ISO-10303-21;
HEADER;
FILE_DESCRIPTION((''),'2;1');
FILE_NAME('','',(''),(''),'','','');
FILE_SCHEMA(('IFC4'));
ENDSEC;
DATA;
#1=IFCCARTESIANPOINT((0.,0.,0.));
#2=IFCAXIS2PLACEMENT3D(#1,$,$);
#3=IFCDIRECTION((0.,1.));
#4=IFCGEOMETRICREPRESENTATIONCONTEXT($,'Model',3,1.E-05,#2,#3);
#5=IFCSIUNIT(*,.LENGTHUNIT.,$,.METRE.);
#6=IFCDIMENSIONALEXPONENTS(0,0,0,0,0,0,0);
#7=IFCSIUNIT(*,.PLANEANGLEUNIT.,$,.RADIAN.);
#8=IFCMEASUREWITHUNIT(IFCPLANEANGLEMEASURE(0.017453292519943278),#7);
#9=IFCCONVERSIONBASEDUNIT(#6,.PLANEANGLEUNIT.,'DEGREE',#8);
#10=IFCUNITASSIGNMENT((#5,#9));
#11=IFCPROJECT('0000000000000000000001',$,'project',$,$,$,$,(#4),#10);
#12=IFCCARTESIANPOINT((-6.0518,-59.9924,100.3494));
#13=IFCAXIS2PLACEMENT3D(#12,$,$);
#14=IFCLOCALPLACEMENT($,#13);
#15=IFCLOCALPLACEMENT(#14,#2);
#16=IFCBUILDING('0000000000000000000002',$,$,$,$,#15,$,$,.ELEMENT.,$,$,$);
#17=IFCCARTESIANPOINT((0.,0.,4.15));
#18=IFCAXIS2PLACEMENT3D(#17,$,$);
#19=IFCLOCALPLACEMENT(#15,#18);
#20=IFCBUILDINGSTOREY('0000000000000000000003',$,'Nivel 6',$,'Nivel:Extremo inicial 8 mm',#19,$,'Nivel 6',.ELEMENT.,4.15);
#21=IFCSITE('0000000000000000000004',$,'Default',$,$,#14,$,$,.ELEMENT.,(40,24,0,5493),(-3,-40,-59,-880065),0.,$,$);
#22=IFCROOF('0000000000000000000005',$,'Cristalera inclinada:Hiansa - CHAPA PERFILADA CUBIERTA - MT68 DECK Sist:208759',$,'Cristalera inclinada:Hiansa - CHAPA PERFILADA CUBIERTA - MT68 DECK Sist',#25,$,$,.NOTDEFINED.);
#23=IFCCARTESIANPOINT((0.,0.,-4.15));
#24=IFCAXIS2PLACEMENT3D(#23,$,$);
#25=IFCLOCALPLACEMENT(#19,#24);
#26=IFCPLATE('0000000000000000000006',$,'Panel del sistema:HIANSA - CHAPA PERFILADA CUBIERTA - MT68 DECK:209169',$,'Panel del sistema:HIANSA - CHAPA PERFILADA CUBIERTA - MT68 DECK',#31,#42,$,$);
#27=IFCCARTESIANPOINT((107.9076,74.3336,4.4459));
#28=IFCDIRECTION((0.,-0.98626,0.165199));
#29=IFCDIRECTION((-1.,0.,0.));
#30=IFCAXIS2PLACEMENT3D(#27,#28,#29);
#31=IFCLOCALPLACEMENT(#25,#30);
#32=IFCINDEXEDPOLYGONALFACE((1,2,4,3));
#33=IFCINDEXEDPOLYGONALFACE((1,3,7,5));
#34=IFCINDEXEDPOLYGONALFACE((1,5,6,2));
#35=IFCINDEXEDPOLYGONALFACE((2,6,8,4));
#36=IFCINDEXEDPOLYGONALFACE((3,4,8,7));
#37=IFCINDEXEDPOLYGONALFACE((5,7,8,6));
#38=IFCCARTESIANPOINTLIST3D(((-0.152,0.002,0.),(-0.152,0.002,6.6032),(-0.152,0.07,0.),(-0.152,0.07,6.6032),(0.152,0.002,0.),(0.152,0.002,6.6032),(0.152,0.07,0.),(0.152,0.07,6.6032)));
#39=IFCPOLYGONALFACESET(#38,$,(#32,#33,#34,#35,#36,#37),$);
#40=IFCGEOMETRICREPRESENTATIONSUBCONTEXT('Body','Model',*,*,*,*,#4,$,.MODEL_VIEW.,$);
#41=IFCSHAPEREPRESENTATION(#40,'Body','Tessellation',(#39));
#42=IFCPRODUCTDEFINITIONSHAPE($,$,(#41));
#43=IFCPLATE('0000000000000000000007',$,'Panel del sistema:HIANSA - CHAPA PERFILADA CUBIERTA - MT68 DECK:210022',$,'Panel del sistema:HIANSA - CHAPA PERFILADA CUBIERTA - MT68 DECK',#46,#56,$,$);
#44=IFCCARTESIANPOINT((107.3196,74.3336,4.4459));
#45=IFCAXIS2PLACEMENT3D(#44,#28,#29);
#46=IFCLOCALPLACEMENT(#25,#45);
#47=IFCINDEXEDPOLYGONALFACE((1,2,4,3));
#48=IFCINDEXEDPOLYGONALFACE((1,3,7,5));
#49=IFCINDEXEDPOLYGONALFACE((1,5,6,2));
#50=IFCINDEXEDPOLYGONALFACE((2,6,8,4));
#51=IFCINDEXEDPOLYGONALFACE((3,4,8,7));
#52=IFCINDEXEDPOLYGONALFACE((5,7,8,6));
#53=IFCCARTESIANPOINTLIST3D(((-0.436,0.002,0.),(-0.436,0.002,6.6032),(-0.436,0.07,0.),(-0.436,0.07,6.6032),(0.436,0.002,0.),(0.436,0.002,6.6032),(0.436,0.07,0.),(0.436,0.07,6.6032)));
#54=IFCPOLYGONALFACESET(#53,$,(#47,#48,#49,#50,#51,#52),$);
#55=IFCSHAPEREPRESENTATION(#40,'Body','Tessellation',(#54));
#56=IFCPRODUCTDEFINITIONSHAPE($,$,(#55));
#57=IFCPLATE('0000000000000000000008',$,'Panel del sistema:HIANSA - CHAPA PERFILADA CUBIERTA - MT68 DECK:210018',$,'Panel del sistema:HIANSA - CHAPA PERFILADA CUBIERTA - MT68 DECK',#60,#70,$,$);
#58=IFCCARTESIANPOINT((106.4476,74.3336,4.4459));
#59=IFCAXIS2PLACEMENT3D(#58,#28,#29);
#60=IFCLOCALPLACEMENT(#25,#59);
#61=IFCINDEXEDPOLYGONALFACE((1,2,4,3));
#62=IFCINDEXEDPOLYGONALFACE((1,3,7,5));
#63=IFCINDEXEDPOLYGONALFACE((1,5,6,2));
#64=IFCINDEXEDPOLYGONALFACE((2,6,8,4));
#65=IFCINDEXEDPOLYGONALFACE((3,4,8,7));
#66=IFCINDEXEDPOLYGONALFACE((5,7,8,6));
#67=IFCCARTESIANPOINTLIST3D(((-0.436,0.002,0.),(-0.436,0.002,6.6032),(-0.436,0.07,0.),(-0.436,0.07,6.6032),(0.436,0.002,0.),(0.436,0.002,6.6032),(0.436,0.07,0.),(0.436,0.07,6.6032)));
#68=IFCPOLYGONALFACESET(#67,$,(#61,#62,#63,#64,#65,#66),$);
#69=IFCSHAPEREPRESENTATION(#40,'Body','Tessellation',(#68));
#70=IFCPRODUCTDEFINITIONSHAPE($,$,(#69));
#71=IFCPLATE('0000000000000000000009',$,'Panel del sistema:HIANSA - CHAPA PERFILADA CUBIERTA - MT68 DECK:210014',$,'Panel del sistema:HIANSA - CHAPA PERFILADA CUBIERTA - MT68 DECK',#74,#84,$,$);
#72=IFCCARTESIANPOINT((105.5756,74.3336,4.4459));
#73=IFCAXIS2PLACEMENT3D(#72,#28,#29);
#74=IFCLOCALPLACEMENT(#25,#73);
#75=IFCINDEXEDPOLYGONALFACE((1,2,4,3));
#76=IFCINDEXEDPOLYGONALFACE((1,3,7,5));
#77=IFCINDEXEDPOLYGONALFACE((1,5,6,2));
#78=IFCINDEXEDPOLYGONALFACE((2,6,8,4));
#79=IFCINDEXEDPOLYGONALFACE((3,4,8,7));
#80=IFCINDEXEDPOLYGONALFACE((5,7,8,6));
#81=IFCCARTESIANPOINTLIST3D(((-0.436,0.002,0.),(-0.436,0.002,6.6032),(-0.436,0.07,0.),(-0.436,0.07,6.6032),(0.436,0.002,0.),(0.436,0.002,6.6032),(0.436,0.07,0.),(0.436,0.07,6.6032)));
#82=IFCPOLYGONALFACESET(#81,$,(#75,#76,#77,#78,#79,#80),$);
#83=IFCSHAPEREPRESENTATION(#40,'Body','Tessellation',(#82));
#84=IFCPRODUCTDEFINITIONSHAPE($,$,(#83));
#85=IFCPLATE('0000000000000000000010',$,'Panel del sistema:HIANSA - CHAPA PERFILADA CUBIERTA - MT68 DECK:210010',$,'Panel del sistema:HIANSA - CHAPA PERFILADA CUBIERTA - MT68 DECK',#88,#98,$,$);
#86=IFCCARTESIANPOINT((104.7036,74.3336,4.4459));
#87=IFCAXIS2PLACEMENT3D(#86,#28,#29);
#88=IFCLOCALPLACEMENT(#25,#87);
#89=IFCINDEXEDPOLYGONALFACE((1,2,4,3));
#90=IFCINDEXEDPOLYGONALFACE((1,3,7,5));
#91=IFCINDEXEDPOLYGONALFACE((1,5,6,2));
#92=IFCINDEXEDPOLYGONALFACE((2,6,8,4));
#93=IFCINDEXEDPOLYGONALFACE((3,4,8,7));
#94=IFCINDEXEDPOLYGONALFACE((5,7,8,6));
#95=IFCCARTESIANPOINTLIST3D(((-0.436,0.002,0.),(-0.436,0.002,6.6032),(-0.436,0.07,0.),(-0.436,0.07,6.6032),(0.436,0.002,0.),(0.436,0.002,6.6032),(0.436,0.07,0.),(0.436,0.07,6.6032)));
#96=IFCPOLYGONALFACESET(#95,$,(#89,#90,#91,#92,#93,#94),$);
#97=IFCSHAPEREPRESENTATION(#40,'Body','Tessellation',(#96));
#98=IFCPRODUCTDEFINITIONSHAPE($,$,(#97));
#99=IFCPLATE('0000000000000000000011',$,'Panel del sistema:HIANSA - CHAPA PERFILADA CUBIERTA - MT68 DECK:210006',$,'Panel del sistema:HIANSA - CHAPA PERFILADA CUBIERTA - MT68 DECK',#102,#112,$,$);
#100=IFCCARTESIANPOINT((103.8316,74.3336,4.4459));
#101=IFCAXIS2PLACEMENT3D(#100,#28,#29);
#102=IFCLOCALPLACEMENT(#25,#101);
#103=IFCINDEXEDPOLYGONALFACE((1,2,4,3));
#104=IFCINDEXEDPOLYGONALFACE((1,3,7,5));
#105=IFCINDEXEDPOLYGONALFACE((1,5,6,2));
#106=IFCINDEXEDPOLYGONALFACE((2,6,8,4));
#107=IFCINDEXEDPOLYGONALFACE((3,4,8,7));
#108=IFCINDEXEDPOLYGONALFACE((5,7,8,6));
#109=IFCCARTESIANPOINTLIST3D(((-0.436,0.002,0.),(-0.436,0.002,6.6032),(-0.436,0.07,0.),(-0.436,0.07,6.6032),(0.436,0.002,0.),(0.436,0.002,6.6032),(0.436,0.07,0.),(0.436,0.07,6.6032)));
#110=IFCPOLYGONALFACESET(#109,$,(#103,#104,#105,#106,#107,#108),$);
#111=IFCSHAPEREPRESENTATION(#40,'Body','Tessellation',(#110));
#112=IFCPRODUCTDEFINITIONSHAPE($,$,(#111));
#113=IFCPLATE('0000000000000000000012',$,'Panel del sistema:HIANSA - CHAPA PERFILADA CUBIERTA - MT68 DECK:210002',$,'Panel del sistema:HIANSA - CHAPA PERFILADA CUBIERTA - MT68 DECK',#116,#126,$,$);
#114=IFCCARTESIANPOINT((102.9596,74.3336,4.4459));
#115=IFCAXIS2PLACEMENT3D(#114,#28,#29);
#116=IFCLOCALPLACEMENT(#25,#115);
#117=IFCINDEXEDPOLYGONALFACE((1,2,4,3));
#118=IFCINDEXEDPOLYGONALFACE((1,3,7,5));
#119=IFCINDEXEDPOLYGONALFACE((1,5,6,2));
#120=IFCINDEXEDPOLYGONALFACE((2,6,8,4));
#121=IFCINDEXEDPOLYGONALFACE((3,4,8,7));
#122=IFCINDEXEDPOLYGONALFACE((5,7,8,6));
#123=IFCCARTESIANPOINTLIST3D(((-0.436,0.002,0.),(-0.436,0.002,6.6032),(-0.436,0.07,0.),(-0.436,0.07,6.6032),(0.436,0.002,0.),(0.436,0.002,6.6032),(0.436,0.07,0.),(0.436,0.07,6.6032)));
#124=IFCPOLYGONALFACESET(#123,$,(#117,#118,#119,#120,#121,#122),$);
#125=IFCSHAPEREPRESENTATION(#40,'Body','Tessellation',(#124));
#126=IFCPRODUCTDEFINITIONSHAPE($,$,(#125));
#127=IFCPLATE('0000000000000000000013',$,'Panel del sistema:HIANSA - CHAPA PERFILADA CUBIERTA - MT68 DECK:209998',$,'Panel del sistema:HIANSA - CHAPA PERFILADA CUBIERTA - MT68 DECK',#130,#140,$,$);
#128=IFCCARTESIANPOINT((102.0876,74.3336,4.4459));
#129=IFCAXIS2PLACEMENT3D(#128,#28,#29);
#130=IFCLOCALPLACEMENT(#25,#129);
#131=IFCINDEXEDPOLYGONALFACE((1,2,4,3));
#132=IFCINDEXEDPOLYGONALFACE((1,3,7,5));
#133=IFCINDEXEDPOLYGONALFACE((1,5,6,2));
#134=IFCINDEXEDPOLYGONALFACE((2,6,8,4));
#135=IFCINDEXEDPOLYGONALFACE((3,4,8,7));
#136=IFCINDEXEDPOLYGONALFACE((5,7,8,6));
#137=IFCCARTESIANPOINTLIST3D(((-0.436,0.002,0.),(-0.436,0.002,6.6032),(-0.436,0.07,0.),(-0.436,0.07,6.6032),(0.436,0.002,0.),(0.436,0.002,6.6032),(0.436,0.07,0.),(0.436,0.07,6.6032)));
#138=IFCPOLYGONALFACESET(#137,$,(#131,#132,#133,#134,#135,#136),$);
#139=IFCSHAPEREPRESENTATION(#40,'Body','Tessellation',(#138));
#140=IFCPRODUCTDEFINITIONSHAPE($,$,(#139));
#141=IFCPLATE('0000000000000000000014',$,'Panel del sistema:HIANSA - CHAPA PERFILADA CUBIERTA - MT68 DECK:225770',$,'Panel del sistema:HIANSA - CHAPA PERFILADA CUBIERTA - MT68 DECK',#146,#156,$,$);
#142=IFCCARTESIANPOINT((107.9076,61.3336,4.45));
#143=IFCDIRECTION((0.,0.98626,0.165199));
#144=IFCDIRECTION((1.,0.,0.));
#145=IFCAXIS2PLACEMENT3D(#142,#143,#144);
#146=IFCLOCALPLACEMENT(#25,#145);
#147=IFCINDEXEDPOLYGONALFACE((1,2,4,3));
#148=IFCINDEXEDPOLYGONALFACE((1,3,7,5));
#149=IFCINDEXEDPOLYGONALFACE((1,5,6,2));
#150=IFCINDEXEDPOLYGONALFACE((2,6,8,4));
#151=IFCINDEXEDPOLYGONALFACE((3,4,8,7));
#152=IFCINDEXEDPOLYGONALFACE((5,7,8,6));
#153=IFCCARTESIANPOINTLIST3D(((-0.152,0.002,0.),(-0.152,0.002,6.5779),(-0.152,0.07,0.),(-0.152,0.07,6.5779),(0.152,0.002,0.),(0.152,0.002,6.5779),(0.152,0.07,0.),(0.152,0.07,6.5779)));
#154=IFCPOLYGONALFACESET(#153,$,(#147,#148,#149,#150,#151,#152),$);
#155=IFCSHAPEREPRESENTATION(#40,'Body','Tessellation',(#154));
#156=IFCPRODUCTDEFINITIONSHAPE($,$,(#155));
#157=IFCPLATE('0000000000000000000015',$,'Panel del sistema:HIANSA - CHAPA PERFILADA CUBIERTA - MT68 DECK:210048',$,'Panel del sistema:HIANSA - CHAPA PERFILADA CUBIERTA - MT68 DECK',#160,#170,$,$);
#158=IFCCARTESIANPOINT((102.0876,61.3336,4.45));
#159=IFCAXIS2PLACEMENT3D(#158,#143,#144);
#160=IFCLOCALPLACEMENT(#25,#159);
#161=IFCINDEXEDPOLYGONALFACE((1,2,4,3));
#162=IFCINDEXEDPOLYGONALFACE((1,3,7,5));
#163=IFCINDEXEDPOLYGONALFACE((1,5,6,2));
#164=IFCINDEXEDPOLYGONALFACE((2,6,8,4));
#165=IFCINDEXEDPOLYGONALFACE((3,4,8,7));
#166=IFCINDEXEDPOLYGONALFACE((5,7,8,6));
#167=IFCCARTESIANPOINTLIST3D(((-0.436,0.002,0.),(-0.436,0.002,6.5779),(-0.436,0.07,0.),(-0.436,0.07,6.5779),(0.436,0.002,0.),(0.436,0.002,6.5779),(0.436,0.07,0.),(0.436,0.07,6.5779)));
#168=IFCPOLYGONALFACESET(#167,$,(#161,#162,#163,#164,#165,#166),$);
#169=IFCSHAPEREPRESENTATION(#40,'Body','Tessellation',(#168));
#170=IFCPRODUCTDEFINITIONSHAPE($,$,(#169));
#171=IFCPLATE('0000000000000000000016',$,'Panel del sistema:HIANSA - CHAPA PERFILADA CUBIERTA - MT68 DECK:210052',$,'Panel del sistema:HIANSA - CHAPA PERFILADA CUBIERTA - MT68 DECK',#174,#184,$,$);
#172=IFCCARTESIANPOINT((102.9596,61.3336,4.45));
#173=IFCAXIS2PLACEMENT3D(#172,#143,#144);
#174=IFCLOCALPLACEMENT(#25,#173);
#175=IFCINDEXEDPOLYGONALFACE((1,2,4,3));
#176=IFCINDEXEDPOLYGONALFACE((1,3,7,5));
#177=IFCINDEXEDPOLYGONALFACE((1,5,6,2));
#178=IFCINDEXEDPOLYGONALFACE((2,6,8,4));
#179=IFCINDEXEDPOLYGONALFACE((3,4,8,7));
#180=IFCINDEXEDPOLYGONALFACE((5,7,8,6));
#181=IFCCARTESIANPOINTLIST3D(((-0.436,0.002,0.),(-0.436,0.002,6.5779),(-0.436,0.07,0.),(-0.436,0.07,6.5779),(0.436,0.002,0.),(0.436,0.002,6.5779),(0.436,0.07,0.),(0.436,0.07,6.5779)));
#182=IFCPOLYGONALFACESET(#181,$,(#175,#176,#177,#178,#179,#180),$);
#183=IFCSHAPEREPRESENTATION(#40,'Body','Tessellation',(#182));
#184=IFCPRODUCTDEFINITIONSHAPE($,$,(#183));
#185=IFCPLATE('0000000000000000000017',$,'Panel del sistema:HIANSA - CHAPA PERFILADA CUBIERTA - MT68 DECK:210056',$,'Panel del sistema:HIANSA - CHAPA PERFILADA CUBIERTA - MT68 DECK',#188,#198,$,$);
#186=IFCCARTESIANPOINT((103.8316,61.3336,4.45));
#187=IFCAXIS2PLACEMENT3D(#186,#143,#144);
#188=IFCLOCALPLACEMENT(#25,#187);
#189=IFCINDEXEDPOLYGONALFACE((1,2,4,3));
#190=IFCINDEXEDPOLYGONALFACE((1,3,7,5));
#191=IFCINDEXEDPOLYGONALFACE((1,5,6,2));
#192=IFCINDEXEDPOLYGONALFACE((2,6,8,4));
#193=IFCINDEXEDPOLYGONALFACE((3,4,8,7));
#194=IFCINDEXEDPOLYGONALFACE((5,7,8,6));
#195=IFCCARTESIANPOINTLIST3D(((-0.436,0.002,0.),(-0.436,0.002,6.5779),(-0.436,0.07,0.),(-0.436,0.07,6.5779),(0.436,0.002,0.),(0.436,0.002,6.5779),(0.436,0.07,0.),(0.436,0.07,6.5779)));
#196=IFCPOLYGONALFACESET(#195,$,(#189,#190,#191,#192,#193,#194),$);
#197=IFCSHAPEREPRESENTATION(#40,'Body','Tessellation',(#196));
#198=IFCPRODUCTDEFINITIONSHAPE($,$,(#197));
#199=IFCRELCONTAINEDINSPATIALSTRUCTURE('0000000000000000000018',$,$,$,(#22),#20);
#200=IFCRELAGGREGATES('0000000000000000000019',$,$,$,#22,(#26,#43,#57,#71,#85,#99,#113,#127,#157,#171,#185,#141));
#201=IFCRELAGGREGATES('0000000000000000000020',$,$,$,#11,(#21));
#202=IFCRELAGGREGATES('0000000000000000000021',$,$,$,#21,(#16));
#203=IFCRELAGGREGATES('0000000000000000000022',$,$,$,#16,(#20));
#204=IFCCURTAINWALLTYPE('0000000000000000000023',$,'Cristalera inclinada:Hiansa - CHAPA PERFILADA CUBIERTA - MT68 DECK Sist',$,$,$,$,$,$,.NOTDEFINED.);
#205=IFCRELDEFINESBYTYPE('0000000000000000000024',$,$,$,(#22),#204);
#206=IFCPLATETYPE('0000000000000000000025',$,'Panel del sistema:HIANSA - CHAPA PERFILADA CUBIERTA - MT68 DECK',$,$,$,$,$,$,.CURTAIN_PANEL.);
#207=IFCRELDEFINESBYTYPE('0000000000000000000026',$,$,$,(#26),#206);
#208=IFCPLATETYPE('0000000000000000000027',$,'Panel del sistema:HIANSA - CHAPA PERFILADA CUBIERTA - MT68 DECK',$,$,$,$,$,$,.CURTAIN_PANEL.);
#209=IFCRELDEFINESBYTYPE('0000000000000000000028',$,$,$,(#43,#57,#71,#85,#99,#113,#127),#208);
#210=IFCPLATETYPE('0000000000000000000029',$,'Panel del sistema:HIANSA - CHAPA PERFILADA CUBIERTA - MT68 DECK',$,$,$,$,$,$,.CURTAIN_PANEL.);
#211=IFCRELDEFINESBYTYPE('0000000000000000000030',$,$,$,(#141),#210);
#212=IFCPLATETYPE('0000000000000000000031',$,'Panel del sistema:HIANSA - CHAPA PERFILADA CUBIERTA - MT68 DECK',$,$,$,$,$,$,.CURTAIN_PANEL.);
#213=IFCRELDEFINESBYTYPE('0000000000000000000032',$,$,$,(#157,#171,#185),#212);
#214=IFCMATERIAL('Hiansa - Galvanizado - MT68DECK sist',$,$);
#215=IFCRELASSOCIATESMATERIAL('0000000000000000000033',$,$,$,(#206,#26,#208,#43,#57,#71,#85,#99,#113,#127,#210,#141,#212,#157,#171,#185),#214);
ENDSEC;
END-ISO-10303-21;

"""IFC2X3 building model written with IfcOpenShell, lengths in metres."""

from ifc_helpers import new_model, entity, si_unit, converted_unit, direction, frame, origin, origin_2d_with_axis, place, context, subcontext, project, spatial, rectangle, extrude, source, transform, mapped, material, type_object, type_shapes, element, aggregate, save


model = new_model("IFC2X3")

# Units and contexts
model_context = context("Model", 3, precision=1e-05, world=origin(), true_north=direction((0.0, 1.0)))
body_context = subcontext(model_context, "Body", "Model", "MODEL_VIEW")
ifc_project = project(units=[si_unit("LENGTHUNIT", "METRE"), converted_unit("PLANEANGLEUNIT", "DEGREE", entity("IfcPlaneAngleMeasure", 0.017453292519943278), si_unit("PLANEANGLEUNIT", "RADIAN"), dimensions=[0, 0, 0, 0, 0, 0, 0])], contexts=[model_context])

# Site, building, storey
site_placement = place(None, frame((-6.0518, -59.9924, 100.3494)))
site = spatial("IfcSite", under=ifc_project, at=site_placement, Name="Default", CompositionType="ELEMENT", RefLatitude=(40, 24, 0, 5493), RefLongitude=(-3, -40, -59, -880065), RefElevation=0.0)
building_placement = place(site_placement, origin())
building = spatial("IfcBuilding", under=site, at=building_placement, CompositionType="ELEMENT")
storey_placement = place(building_placement, frame((0.0, 0.0, 4.15)))
storey = spatial("IfcBuildingStorey", under=building, at=storey_placement, Name="Nivel 6", ObjectType="Nivel:Extremo inicial 8 mm", LongName="Nivel 6", CompositionType="ELEMENT", Elevation=4.15)

# Roof, plates
curtain_wall_type = type_object("IfcCurtainWallType", Name="Cristalera inclinada:Hiansa - CHAPA PERFILADA CUBIERTA - MT68 DECK Sist", PredefinedType="NOTDEFINED")
roof_placement = place(storey_placement, frame((0.0, 0.0, -4.15)))
roof = element("IfcRoof", 1, at=roof_placement, inside=storey, type_object=curtain_wall_type, Name="Cristalera inclinada:Hiansa - CHAPA PERFILADA CUBIERTA - MT68 DECK Sist:208759", ObjectType="Cristalera inclinada:Hiansa - CHAPA PERFILADA CUBIERTA - MT68 DECK Sist", ShapeType="NOTDEFINED")
ifc_material_1 = material(Name="Hiansa - Galvanizado - MT68DECK sist")
plate_type_1 = type_object("IfcPlateType", Name="Panel del sistema:HIANSA - CHAPA PERFILADA CUBIERTA - MT68 DECK", PredefinedType="CURTAIN_PANEL", material=ifc_material_1)
shared_shape_1 = source(origin(), body_context, "Body", "SweptSolid", [
    extrude(rectangle(XDim=0.068, YDim=0.304, at=origin_2d_with_axis()), frame((0.0, 0.036, 0.0), z_axis=(0.0, 0.0, 1.0), x_axis=(0.0, 1.0, 0.0)), (0.0, 0.0, 1.0), 6.6032),
])
type_shapes(plate_type_1, [shared_shape_1])
plate_1_placement = place(roof_placement, frame((107.9076, 74.3336, 4.4459), z_axis=(0.0, -0.98626, 0.165199), x_axis=(-1.0, 0.0, 0.0)))
plate_1 = element("IfcPlate", 2, at=plate_1_placement, type_object=plate_type_1, material=ifc_material_1, Name="Panel del sistema:HIANSA - CHAPA PERFILADA CUBIERTA - MT68 DECK:209169", ObjectType="Panel del sistema:HIANSA - CHAPA PERFILADA CUBIERTA - MT68 DECK", context=body_context, shape_type="MappedRepresentation", body=[
    mapped(shared_shape_1, transform((0.0, 0.0, 0.0), scale=1.0)),
])
plate_type_2 = type_object("IfcPlateType", Name="Panel del sistema:HIANSA - CHAPA PERFILADA CUBIERTA - MT68 DECK", PredefinedType="CURTAIN_PANEL", material=ifc_material_1)
shared_shape_2 = source(origin(), body_context, "Body", "SweptSolid", [
    extrude(rectangle(XDim=0.068, YDim=0.872, at=origin_2d_with_axis()), frame((0.0, 0.036, 0.0), z_axis=(0.0, 0.0, 1.0), x_axis=(0.0, 1.0, 0.0)), (0.0, 0.0, 1.0), 6.6032),
])
type_shapes(plate_type_2, [shared_shape_2])
plate_2_placement = place(roof_placement, frame((107.3196, 74.3336, 4.4459), z_axis=(0.0, -0.98626, 0.165199), x_axis=(-1.0, 0.0, 0.0)))
plate_2 = element("IfcPlate", 3, at=plate_2_placement, type_object=plate_type_2, material=ifc_material_1, Name="Panel del sistema:HIANSA - CHAPA PERFILADA CUBIERTA - MT68 DECK:210022", ObjectType="Panel del sistema:HIANSA - CHAPA PERFILADA CUBIERTA - MT68 DECK", context=body_context, shape_type="MappedRepresentation", body=[
    mapped(shared_shape_2, transform((0.0, 0.0, 0.0), scale=1.0)),
])
plate_3_placement = place(roof_placement, frame((106.4476, 74.3336, 4.4459), z_axis=(0.0, -0.98626, 0.165199), x_axis=(-1.0, 0.0, 0.0)))
plate_3 = element("IfcPlate", 4, at=plate_3_placement, type_object=plate_type_2, material=ifc_material_1, Name="Panel del sistema:HIANSA - CHAPA PERFILADA CUBIERTA - MT68 DECK:210018", ObjectType="Panel del sistema:HIANSA - CHAPA PERFILADA CUBIERTA - MT68 DECK", context=body_context, shape_type="MappedRepresentation", body=[
    mapped(shared_shape_2, transform((0.0, 0.0, 0.0), scale=1.0)),
])
plate_4_placement = place(roof_placement, frame((105.5756, 74.3336, 4.4459), z_axis=(0.0, -0.98626, 0.165199), x_axis=(-1.0, 0.0, 0.0)))
plate_4 = element("IfcPlate", 5, at=plate_4_placement, type_object=plate_type_2, material=ifc_material_1, Name="Panel del sistema:HIANSA - CHAPA PERFILADA CUBIERTA - MT68 DECK:210014", ObjectType="Panel del sistema:HIANSA - CHAPA PERFILADA CUBIERTA - MT68 DECK", context=body_context, shape_type="MappedRepresentation", body=[
    mapped(shared_shape_2, transform((0.0, 0.0, 0.0), scale=1.0)),
])
plate_5_placement = place(roof_placement, frame((104.7036, 74.3336, 4.4459), z_axis=(0.0, -0.98626, 0.165199), x_axis=(-1.0, 0.0, 0.0)))
plate_5 = element("IfcPlate", 6, at=plate_5_placement, type_object=plate_type_2, material=ifc_material_1, Name="Panel del sistema:HIANSA - CHAPA PERFILADA CUBIERTA - MT68 DECK:210010", ObjectType="Panel del sistema:HIANSA - CHAPA PERFILADA CUBIERTA - MT68 DECK", context=body_context, shape_type="MappedRepresentation", body=[
    mapped(shared_shape_2, transform((0.0, 0.0, 0.0), scale=1.0)),
])
plate_6_placement = place(roof_placement, frame((103.8316, 74.3336, 4.4459), z_axis=(0.0, -0.98626, 0.165199), x_axis=(-1.0, 0.0, 0.0)))
plate_6 = element("IfcPlate", 7, at=plate_6_placement, type_object=plate_type_2, material=ifc_material_1, Name="Panel del sistema:HIANSA - CHAPA PERFILADA CUBIERTA - MT68 DECK:210006", ObjectType="Panel del sistema:HIANSA - CHAPA PERFILADA CUBIERTA - MT68 DECK", context=body_context, shape_type="MappedRepresentation", body=[
    mapped(shared_shape_2, transform((0.0, 0.0, 0.0), scale=1.0)),
])
plate_7_placement = place(roof_placement, frame((102.9596, 74.3336, 4.4459), z_axis=(0.0, -0.98626, 0.165199), x_axis=(-1.0, 0.0, 0.0)))
plate_7 = element("IfcPlate", 8, at=plate_7_placement, type_object=plate_type_2, material=ifc_material_1, Name="Panel del sistema:HIANSA - CHAPA PERFILADA CUBIERTA - MT68 DECK:210002", ObjectType="Panel del sistema:HIANSA - CHAPA PERFILADA CUBIERTA - MT68 DECK", context=body_context, shape_type="MappedRepresentation", body=[
    mapped(shared_shape_2, transform((0.0, 0.0, 0.0), scale=1.0)),
])
plate_8_placement = place(roof_placement, frame((102.0876, 74.3336, 4.4459), z_axis=(0.0, -0.98626, 0.165199), x_axis=(-1.0, 0.0, 0.0)))
plate_8 = element("IfcPlate", 9, at=plate_8_placement, type_object=plate_type_2, material=ifc_material_1, Name="Panel del sistema:HIANSA - CHAPA PERFILADA CUBIERTA - MT68 DECK:209998", ObjectType="Panel del sistema:HIANSA - CHAPA PERFILADA CUBIERTA - MT68 DECK", context=body_context, shape_type="MappedRepresentation", body=[
    mapped(shared_shape_2, transform((0.0, 0.0, 0.0), scale=1.0)),
])
plate_type_3 = type_object("IfcPlateType", Name="Panel del sistema:HIANSA - CHAPA PERFILADA CUBIERTA - MT68 DECK", PredefinedType="CURTAIN_PANEL", material=ifc_material_1)
shared_shape_3 = source(origin(), body_context, "Body", "SweptSolid", [
    extrude(rectangle(XDim=0.068, YDim=0.304, at=origin_2d_with_axis()), frame((0.0, 0.036, 0.0), z_axis=(0.0, 0.0, 1.0), x_axis=(0.0, 1.0, 0.0)), (0.0, 0.0, 1.0), 6.5779),
])
type_shapes(plate_type_3, [shared_shape_3])
plate_9_placement = place(roof_placement, frame((107.9076, 61.3336, 4.45), z_axis=(0.0, 0.98626, 0.165199), x_axis=(1.0, 0.0, 0.0)))
plate_9 = element("IfcPlate", 10, at=plate_9_placement, type_object=plate_type_3, material=ifc_material_1, Name="Panel del sistema:HIANSA - CHAPA PERFILADA CUBIERTA - MT68 DECK:225770", ObjectType="Panel del sistema:HIANSA - CHAPA PERFILADA CUBIERTA - MT68 DECK", context=body_context, shape_type="MappedRepresentation", body=[
    mapped(shared_shape_3, transform((0.0, 0.0, 0.0), scale=1.0)),
])
plate_type_4 = type_object("IfcPlateType", Name="Panel del sistema:HIANSA - CHAPA PERFILADA CUBIERTA - MT68 DECK", PredefinedType="CURTAIN_PANEL", material=ifc_material_1)
shared_shape_4 = source(origin(), body_context, "Body", "SweptSolid", [
    extrude(rectangle(XDim=0.068, YDim=0.872, at=origin_2d_with_axis()), frame((0.0, 0.036, 0.0), z_axis=(0.0, 0.0, 1.0), x_axis=(0.0, 1.0, 0.0)), (0.0, 0.0, 1.0), 6.5779),
])
type_shapes(plate_type_4, [shared_shape_4])
plate_10_placement = place(roof_placement, frame((102.0876, 61.3336, 4.45), z_axis=(0.0, 0.98626, 0.165199), x_axis=(1.0, 0.0, 0.0)))
plate_10 = element("IfcPlate", 11, at=plate_10_placement, type_object=plate_type_4, material=ifc_material_1, Name="Panel del sistema:HIANSA - CHAPA PERFILADA CUBIERTA - MT68 DECK:210048", ObjectType="Panel del sistema:HIANSA - CHAPA PERFILADA CUBIERTA - MT68 DECK", context=body_context, shape_type="MappedRepresentation", body=[
    mapped(shared_shape_4, transform((0.0, 0.0, 0.0), scale=1.0)),
])
plate_11_placement = place(roof_placement, frame((102.9596, 61.3336, 4.45), z_axis=(0.0, 0.98626, 0.165199), x_axis=(1.0, 0.0, 0.0)))
plate_11 = element("IfcPlate", 12, at=plate_11_placement, type_object=plate_type_4, material=ifc_material_1, Name="Panel del sistema:HIANSA - CHAPA PERFILADA CUBIERTA - MT68 DECK:210052", ObjectType="Panel del sistema:HIANSA - CHAPA PERFILADA CUBIERTA - MT68 DECK", context=body_context, shape_type="MappedRepresentation", body=[
    mapped(shared_shape_4, transform((0.0, 0.0, 0.0), scale=1.0)),
])
plate_12_placement = place(roof_placement, frame((103.8316, 61.3336, 4.45), z_axis=(0.0, 0.98626, 0.165199), x_axis=(1.0, 0.0, 0.0)))
plate_12 = element("IfcPlate", 13, at=plate_12_placement, type_object=plate_type_4, material=ifc_material_1, Name="Panel del sistema:HIANSA - CHAPA PERFILADA CUBIERTA - MT68 DECK:210056", ObjectType="Panel del sistema:HIANSA - CHAPA PERFILADA CUBIERTA - MT68 DECK", context=body_context, shape_type="MappedRepresentation", body=[
    mapped(shared_shape_4, transform((0.0, 0.0, 0.0), scale=1.0)),
])
aggregate(roof, [plate_1, plate_2, plate_3, plate_4, plate_5, plate_6, plate_7, plate_8, plate_10, plate_11, plate_12, plate_9])

save(model, "model.ifc")
